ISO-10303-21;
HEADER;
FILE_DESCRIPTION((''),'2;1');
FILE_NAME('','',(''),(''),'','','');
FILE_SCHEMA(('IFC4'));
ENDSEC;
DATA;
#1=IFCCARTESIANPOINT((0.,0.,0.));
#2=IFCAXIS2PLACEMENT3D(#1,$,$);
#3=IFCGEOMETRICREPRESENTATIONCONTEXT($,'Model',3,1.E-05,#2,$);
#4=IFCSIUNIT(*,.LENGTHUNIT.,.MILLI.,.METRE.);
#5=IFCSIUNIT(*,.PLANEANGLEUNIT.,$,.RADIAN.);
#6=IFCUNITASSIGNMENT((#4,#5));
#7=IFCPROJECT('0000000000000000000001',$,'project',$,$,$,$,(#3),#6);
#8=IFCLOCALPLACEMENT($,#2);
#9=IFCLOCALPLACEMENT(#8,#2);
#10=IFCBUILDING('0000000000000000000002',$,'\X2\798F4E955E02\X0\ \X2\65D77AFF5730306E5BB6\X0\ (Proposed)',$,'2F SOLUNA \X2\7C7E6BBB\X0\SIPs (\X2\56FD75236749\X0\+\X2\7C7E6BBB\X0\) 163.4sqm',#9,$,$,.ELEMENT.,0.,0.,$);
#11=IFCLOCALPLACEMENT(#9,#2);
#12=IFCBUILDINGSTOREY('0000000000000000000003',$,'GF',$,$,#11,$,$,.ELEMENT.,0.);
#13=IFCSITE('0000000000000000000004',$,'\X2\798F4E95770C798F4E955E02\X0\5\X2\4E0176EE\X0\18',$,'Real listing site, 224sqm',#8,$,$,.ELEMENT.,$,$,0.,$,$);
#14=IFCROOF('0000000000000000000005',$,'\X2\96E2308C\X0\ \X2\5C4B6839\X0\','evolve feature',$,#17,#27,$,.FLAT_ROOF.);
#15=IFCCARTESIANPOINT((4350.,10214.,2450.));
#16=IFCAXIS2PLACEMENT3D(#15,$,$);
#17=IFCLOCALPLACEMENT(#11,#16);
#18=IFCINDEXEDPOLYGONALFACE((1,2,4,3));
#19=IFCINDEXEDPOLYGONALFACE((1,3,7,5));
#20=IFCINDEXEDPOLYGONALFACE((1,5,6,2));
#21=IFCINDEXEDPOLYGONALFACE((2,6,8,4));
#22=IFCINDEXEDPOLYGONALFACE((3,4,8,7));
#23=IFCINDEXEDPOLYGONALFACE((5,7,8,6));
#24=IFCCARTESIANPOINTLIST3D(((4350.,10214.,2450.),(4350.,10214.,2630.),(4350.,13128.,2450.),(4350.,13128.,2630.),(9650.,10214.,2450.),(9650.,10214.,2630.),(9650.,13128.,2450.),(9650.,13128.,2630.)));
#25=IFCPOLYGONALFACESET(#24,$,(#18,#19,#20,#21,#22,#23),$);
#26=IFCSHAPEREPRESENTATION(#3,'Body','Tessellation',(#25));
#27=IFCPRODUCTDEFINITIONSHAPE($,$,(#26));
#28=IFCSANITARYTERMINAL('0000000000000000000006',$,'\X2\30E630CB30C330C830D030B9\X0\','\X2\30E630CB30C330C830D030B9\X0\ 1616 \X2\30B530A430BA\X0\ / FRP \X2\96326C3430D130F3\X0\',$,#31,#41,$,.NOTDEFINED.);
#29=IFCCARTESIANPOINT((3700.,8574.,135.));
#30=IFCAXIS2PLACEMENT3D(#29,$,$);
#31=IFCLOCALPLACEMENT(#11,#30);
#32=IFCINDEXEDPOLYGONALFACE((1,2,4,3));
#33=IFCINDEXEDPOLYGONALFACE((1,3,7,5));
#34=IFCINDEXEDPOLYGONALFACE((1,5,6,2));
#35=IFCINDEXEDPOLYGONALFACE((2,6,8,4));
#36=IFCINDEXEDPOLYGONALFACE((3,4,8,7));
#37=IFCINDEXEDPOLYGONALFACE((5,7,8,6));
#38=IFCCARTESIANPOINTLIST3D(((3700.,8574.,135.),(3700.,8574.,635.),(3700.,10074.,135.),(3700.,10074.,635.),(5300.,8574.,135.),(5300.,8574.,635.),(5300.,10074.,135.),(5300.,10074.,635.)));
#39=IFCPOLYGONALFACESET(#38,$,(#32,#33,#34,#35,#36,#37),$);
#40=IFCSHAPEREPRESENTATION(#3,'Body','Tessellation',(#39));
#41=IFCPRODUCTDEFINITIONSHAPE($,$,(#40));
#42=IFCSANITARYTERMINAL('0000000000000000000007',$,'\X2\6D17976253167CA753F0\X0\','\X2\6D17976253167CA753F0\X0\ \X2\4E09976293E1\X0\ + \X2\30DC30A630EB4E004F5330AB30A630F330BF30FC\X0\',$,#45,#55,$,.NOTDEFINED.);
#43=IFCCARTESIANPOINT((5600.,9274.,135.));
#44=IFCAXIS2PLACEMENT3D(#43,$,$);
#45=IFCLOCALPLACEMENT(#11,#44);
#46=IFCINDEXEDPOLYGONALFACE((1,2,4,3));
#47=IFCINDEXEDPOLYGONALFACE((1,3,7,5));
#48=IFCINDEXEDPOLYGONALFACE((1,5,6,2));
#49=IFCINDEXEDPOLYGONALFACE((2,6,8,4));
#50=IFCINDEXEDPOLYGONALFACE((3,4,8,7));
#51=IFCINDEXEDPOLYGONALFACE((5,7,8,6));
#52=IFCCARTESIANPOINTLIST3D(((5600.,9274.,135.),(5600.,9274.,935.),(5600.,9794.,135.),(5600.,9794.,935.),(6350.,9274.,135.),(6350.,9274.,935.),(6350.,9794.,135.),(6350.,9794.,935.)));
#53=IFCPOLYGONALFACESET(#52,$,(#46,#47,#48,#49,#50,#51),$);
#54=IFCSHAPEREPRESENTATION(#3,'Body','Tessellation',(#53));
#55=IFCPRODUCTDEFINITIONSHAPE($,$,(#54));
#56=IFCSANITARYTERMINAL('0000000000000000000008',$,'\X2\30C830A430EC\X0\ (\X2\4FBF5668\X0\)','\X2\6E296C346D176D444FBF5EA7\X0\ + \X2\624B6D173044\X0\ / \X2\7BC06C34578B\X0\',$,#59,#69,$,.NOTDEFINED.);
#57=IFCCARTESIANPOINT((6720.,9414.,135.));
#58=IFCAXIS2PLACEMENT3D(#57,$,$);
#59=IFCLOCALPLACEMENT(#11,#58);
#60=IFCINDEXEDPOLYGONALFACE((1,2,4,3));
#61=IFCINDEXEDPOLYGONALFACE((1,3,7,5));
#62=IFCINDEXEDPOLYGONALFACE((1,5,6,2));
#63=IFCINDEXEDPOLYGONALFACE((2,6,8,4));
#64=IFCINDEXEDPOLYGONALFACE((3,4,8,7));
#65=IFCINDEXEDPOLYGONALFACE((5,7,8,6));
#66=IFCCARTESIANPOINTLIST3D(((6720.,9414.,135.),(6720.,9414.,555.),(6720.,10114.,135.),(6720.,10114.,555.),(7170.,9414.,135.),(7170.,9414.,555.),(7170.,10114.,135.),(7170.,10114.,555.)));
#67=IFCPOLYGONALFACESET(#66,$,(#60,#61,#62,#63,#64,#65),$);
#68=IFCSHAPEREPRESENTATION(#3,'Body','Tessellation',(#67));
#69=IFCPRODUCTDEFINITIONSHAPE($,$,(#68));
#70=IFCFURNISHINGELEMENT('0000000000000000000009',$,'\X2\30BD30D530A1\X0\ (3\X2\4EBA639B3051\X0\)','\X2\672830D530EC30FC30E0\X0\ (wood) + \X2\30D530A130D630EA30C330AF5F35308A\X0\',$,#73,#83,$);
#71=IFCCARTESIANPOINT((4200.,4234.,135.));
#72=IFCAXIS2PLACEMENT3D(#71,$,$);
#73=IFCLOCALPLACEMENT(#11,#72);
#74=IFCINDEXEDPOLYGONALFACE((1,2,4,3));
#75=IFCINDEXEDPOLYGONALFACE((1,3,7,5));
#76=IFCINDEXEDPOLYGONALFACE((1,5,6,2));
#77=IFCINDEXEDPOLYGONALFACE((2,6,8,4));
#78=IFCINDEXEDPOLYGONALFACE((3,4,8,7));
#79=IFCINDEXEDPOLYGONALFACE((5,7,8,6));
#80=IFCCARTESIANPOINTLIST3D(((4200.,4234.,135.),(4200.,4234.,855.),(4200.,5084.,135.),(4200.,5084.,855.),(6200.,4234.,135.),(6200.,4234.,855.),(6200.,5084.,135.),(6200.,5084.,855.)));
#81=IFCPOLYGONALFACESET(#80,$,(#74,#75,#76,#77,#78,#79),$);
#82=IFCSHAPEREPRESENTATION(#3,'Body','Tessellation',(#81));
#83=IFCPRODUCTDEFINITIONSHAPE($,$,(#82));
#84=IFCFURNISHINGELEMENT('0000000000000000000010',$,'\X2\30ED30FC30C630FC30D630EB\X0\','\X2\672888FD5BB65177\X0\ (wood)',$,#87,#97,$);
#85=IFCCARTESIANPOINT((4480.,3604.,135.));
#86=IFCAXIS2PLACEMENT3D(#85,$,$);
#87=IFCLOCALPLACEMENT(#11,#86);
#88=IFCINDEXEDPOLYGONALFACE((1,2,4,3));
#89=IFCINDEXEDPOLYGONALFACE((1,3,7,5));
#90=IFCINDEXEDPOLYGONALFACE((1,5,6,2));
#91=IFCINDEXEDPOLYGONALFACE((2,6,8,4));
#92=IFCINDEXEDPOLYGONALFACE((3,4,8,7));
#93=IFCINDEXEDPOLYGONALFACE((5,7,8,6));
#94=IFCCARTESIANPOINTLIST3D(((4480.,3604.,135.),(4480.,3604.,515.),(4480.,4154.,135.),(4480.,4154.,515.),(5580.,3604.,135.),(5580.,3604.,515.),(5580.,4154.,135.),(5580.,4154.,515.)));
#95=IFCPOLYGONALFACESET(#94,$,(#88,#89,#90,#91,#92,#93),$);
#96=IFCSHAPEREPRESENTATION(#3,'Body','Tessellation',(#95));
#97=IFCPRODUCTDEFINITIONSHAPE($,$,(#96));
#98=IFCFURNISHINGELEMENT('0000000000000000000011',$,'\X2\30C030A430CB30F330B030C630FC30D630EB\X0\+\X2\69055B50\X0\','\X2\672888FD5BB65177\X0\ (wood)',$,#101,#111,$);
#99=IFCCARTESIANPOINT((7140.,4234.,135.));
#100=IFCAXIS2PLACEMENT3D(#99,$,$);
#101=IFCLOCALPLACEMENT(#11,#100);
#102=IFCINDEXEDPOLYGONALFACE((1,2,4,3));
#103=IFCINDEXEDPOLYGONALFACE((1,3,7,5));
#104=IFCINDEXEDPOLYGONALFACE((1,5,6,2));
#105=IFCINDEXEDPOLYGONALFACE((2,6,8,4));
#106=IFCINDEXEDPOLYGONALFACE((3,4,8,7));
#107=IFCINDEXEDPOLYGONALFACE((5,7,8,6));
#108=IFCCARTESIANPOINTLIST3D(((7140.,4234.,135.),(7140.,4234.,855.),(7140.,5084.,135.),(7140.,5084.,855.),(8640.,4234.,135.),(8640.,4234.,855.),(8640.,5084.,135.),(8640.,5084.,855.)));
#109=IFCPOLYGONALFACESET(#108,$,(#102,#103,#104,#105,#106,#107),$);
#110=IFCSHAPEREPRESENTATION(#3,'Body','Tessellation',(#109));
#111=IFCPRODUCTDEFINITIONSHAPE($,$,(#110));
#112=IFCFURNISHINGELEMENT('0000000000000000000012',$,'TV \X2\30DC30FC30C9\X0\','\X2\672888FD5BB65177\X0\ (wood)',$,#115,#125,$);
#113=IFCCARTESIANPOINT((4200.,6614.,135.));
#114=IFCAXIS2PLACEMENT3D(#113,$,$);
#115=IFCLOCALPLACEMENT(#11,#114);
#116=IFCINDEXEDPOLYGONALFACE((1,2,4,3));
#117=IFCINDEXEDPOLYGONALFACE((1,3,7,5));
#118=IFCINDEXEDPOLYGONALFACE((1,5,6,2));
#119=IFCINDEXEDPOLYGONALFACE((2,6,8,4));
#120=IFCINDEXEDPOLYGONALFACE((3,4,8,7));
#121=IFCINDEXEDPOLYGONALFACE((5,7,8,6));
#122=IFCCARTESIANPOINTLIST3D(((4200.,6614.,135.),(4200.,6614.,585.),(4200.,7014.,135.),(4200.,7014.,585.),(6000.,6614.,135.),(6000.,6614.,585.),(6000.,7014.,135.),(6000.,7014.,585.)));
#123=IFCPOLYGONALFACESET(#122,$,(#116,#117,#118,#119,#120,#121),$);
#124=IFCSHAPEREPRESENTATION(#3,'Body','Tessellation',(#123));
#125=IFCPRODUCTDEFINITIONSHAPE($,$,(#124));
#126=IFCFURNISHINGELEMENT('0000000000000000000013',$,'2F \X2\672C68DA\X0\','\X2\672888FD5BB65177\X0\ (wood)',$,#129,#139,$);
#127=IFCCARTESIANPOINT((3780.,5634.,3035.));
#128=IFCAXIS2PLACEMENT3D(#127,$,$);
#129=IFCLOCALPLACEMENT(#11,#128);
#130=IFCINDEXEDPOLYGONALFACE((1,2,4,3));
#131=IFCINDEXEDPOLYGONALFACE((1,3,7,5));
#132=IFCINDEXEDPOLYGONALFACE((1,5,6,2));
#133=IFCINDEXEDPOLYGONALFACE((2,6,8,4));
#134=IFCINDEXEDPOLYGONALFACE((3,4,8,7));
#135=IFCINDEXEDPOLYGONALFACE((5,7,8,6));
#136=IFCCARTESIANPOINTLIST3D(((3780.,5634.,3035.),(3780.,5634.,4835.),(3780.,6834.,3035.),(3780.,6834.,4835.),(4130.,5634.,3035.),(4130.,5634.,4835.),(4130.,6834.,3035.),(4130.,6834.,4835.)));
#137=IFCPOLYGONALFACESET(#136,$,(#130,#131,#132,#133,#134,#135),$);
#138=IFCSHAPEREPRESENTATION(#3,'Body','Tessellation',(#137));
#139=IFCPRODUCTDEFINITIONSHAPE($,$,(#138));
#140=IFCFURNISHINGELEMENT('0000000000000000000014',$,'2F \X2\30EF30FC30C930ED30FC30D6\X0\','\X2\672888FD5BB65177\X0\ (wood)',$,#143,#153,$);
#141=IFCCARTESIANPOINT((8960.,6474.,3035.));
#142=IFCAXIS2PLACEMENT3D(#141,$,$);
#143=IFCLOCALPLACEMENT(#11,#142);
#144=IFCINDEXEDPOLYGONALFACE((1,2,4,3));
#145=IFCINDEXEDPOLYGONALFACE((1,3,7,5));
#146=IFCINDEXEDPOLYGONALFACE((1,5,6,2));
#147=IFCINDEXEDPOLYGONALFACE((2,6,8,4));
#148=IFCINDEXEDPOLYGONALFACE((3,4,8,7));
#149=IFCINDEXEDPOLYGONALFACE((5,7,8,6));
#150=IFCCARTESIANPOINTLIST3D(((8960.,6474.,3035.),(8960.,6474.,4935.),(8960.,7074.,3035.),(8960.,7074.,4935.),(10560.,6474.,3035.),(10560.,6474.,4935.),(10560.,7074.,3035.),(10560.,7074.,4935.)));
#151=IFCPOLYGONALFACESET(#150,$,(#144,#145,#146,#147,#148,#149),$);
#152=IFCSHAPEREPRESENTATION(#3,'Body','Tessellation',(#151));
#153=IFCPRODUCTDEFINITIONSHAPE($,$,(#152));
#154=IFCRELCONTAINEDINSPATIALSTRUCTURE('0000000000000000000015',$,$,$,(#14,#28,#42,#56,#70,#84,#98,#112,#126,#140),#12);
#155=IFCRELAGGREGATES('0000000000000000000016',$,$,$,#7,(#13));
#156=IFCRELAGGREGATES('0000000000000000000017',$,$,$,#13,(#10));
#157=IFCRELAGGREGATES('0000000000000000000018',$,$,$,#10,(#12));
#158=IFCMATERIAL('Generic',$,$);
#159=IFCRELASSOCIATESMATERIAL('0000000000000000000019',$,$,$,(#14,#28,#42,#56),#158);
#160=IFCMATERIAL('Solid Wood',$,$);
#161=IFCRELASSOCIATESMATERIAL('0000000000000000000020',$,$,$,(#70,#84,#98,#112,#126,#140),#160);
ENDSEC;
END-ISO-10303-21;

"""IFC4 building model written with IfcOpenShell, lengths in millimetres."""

from ifc_helpers import new_model, si_unit, frame, frame_2d, origin, place, context, project, spatial, rectangle, extrude, material, element, save


model = new_model("IFC4")

# Units and contexts
model_context = context("Model", 3, precision=1e-05, world=origin())
ifc_project = project(units=[si_unit("LENGTHUNIT", "METRE", prefix="MILLI"), si_unit("PLANEANGLEUNIT", "RADIAN")], contexts=[model_context])

# Site, building, storey
site_placement = place(None, origin())
site = spatial("IfcSite", under=ifc_project, at=site_placement, Name="福井県福井市5丁目18", ObjectType="Real listing site, 224sqm", CompositionType="ELEMENT", RefElevation=0.0)
building_placement = place(site_placement, origin())
building = spatial("IfcBuilding", under=site, at=building_placement, Name="福井市 旗竿地の家 (Proposed)", ObjectType="2F SOLUNA 籾殻SIPs (国産杉+籾殻) 163.4sqm", CompositionType="ELEMENT", ElevationOfRefHeight=0.0, ElevationOfTerrain=0.0)
storey_placement = place(building_placement, origin())
storey = spatial("IfcBuildingStorey", under=building, at=storey_placement, Name="GF", CompositionType="ELEMENT", Elevation=0.0)

# Shared definitions
ifc_material_1 = material(Name="Generic")

# Shared definitions
ifc_material_2 = material(Name="Solid Wood")

# Roof
roof_placement = place(storey_placement, frame((4350.0, 10214.0, 2450.0)))
element("IfcRoof", 1, at=roof_placement, inside=storey, material=ifc_material_1, Name="離れ 屋根", Description="evolve feature", PredefinedType="FLAT_ROOF", context=model_context, shape_type="SweptSolid", body=[
    extrude(rectangle(XDim=5300.0, YDim=2914.0, at=frame_2d((2650.0, 1457.0))), frame((4350.0, 10214.0, 2450.0)), (0.0, 0.0, 1.0), 180.0),
])

# Sanitary terminals
sanitary_terminal_1_placement = place(storey_placement, frame((3700.0, 8574.0, 135.0)))
element("IfcSanitaryTerminal", 2, at=sanitary_terminal_1_placement, inside=storey, material=ifc_material_1, Name="ユニットバス", Description="ユニットバス 1616 サイズ / FRP 防水パン", PredefinedType="NOTDEFINED", context=model_context, shape_type="SweptSolid", body=[
    extrude(rectangle(XDim=1600.0, YDim=1500.0, at=frame_2d((800.0, 750.0))), frame((3700.0, 8574.0, 135.0)), (0.0, 0.0, 1.0), 500.0),
])
sanitary_terminal_2_placement = place(storey_placement, frame((5600.0, 9274.0, 135.0)))
element("IfcSanitaryTerminal", 3, at=sanitary_terminal_2_placement, inside=storey, material=ifc_material_1, Name="洗面化粧台", Description="洗面化粧台 三面鏡 + ボウル一体カウンター", PredefinedType="NOTDEFINED", context=model_context, shape_type="SweptSolid", body=[
    extrude(rectangle(XDim=750.0, YDim=520.0, at=frame_2d((375.0, 260.0))), frame((5600.0, 9274.0, 135.0)), (0.0, 0.0, 1.0), 800.0),
])
sanitary_terminal_3_placement = place(storey_placement, frame((6720.0, 9414.0, 135.0)))
element("IfcSanitaryTerminal", 4, at=sanitary_terminal_3_placement, inside=storey, material=ifc_material_1, Name="トイレ (便器)", Description="温水洗浄便座 + 手洗い / 節水型", PredefinedType="NOTDEFINED", context=model_context, shape_type="SweptSolid", body=[
    extrude(rectangle(XDim=450.0, YDim=700.0, at=frame_2d((225.0, 350.0))), frame((6720.0, 9414.0, 135.0)), (0.0, 0.0, 1.0), 420.0),
])

# Furnishing elements
furnishing_1_placement = place(storey_placement, frame((4200.0, 4234.0, 135.0)))
element("IfcFurnishingElement", 5, at=furnishing_1_placement, inside=storey, material=ifc_material_2, Name="ソファ (3人掛け)", Description="木フレーム (wood) + ファブリック張り", context=model_context, shape_type="SweptSolid", body=[
    extrude(rectangle(XDim=2000.0, YDim=850.0, at=frame_2d((1000.0, 425.0))), frame((4200.0, 4234.0, 135.0)), (0.0, 0.0, 1.0), 720.0),
])
furnishing_2_placement = place(storey_placement, frame((4480.0, 3604.0, 135.0)))
element("IfcFurnishingElement", 6, at=furnishing_2_placement, inside=storey, material=ifc_material_2, Name="ローテーブル", Description="木製家具 (wood)", context=model_context, shape_type="SweptSolid", body=[
    extrude(rectangle(XDim=1100.0, YDim=550.0, at=frame_2d((550.0, 275.0))), frame((4480.0, 3604.0, 135.0)), (0.0, 0.0, 1.0), 380.0),
])
furnishing_3_placement = place(storey_placement, frame((7140.0, 4234.0, 135.0)))
element("IfcFurnishingElement", 7, at=furnishing_3_placement, inside=storey, material=ifc_material_2, Name="ダイニングテーブル+椅子", Description="木製家具 (wood)", context=model_context, shape_type="SweptSolid", body=[
    extrude(rectangle(XDim=1500.0, YDim=850.0, at=frame_2d((750.0, 425.0))), frame((7140.0, 4234.0, 135.0)), (0.0, 0.0, 1.0), 720.0),
])
furnishing_4_placement = place(storey_placement, frame((4200.0, 6614.0, 135.0)))
element("IfcFurnishingElement", 8, at=furnishing_4_placement, inside=storey, material=ifc_material_2, Name="TV ボード", Description="木製家具 (wood)", context=model_context, shape_type="SweptSolid", body=[
    extrude(rectangle(XDim=1800.0, YDim=400.0, at=frame_2d((900.0, 200.0))), frame((4200.0, 6614.0, 135.0)), (0.0, 0.0, 1.0), 450.0),
])
furnishing_5_placement = place(storey_placement, frame((3780.0, 5634.0, 3035.0)))
element("IfcFurnishingElement", 9, at=furnishing_5_placement, inside=storey, material=ifc_material_2, Name="2F 本棚", Description="木製家具 (wood)", context=model_context, shape_type="SweptSolid", body=[
    extrude(rectangle(XDim=350.0, YDim=1200.0, at=frame_2d((175.0, 600.0))), frame((3780.0, 5634.0, 3035.0)), (0.0, 0.0, 1.0), 1800.0),
])
furnishing_6_placement = place(storey_placement, frame((8960.0, 6474.0, 3035.0)))
element("IfcFurnishingElement", 10, at=furnishing_6_placement, inside=storey, material=ifc_material_2, Name="2F ワードローブ", Description="木製家具 (wood)", context=model_context, shape_type="SweptSolid", body=[
    extrude(rectangle(XDim=1600.0, YDim=600.0, at=frame_2d((800.0, 300.0))), frame((8960.0, 6474.0, 3035.0)), (0.0, 0.0, 1.0), 1900.0),
])

save(model, "model.ifc")
